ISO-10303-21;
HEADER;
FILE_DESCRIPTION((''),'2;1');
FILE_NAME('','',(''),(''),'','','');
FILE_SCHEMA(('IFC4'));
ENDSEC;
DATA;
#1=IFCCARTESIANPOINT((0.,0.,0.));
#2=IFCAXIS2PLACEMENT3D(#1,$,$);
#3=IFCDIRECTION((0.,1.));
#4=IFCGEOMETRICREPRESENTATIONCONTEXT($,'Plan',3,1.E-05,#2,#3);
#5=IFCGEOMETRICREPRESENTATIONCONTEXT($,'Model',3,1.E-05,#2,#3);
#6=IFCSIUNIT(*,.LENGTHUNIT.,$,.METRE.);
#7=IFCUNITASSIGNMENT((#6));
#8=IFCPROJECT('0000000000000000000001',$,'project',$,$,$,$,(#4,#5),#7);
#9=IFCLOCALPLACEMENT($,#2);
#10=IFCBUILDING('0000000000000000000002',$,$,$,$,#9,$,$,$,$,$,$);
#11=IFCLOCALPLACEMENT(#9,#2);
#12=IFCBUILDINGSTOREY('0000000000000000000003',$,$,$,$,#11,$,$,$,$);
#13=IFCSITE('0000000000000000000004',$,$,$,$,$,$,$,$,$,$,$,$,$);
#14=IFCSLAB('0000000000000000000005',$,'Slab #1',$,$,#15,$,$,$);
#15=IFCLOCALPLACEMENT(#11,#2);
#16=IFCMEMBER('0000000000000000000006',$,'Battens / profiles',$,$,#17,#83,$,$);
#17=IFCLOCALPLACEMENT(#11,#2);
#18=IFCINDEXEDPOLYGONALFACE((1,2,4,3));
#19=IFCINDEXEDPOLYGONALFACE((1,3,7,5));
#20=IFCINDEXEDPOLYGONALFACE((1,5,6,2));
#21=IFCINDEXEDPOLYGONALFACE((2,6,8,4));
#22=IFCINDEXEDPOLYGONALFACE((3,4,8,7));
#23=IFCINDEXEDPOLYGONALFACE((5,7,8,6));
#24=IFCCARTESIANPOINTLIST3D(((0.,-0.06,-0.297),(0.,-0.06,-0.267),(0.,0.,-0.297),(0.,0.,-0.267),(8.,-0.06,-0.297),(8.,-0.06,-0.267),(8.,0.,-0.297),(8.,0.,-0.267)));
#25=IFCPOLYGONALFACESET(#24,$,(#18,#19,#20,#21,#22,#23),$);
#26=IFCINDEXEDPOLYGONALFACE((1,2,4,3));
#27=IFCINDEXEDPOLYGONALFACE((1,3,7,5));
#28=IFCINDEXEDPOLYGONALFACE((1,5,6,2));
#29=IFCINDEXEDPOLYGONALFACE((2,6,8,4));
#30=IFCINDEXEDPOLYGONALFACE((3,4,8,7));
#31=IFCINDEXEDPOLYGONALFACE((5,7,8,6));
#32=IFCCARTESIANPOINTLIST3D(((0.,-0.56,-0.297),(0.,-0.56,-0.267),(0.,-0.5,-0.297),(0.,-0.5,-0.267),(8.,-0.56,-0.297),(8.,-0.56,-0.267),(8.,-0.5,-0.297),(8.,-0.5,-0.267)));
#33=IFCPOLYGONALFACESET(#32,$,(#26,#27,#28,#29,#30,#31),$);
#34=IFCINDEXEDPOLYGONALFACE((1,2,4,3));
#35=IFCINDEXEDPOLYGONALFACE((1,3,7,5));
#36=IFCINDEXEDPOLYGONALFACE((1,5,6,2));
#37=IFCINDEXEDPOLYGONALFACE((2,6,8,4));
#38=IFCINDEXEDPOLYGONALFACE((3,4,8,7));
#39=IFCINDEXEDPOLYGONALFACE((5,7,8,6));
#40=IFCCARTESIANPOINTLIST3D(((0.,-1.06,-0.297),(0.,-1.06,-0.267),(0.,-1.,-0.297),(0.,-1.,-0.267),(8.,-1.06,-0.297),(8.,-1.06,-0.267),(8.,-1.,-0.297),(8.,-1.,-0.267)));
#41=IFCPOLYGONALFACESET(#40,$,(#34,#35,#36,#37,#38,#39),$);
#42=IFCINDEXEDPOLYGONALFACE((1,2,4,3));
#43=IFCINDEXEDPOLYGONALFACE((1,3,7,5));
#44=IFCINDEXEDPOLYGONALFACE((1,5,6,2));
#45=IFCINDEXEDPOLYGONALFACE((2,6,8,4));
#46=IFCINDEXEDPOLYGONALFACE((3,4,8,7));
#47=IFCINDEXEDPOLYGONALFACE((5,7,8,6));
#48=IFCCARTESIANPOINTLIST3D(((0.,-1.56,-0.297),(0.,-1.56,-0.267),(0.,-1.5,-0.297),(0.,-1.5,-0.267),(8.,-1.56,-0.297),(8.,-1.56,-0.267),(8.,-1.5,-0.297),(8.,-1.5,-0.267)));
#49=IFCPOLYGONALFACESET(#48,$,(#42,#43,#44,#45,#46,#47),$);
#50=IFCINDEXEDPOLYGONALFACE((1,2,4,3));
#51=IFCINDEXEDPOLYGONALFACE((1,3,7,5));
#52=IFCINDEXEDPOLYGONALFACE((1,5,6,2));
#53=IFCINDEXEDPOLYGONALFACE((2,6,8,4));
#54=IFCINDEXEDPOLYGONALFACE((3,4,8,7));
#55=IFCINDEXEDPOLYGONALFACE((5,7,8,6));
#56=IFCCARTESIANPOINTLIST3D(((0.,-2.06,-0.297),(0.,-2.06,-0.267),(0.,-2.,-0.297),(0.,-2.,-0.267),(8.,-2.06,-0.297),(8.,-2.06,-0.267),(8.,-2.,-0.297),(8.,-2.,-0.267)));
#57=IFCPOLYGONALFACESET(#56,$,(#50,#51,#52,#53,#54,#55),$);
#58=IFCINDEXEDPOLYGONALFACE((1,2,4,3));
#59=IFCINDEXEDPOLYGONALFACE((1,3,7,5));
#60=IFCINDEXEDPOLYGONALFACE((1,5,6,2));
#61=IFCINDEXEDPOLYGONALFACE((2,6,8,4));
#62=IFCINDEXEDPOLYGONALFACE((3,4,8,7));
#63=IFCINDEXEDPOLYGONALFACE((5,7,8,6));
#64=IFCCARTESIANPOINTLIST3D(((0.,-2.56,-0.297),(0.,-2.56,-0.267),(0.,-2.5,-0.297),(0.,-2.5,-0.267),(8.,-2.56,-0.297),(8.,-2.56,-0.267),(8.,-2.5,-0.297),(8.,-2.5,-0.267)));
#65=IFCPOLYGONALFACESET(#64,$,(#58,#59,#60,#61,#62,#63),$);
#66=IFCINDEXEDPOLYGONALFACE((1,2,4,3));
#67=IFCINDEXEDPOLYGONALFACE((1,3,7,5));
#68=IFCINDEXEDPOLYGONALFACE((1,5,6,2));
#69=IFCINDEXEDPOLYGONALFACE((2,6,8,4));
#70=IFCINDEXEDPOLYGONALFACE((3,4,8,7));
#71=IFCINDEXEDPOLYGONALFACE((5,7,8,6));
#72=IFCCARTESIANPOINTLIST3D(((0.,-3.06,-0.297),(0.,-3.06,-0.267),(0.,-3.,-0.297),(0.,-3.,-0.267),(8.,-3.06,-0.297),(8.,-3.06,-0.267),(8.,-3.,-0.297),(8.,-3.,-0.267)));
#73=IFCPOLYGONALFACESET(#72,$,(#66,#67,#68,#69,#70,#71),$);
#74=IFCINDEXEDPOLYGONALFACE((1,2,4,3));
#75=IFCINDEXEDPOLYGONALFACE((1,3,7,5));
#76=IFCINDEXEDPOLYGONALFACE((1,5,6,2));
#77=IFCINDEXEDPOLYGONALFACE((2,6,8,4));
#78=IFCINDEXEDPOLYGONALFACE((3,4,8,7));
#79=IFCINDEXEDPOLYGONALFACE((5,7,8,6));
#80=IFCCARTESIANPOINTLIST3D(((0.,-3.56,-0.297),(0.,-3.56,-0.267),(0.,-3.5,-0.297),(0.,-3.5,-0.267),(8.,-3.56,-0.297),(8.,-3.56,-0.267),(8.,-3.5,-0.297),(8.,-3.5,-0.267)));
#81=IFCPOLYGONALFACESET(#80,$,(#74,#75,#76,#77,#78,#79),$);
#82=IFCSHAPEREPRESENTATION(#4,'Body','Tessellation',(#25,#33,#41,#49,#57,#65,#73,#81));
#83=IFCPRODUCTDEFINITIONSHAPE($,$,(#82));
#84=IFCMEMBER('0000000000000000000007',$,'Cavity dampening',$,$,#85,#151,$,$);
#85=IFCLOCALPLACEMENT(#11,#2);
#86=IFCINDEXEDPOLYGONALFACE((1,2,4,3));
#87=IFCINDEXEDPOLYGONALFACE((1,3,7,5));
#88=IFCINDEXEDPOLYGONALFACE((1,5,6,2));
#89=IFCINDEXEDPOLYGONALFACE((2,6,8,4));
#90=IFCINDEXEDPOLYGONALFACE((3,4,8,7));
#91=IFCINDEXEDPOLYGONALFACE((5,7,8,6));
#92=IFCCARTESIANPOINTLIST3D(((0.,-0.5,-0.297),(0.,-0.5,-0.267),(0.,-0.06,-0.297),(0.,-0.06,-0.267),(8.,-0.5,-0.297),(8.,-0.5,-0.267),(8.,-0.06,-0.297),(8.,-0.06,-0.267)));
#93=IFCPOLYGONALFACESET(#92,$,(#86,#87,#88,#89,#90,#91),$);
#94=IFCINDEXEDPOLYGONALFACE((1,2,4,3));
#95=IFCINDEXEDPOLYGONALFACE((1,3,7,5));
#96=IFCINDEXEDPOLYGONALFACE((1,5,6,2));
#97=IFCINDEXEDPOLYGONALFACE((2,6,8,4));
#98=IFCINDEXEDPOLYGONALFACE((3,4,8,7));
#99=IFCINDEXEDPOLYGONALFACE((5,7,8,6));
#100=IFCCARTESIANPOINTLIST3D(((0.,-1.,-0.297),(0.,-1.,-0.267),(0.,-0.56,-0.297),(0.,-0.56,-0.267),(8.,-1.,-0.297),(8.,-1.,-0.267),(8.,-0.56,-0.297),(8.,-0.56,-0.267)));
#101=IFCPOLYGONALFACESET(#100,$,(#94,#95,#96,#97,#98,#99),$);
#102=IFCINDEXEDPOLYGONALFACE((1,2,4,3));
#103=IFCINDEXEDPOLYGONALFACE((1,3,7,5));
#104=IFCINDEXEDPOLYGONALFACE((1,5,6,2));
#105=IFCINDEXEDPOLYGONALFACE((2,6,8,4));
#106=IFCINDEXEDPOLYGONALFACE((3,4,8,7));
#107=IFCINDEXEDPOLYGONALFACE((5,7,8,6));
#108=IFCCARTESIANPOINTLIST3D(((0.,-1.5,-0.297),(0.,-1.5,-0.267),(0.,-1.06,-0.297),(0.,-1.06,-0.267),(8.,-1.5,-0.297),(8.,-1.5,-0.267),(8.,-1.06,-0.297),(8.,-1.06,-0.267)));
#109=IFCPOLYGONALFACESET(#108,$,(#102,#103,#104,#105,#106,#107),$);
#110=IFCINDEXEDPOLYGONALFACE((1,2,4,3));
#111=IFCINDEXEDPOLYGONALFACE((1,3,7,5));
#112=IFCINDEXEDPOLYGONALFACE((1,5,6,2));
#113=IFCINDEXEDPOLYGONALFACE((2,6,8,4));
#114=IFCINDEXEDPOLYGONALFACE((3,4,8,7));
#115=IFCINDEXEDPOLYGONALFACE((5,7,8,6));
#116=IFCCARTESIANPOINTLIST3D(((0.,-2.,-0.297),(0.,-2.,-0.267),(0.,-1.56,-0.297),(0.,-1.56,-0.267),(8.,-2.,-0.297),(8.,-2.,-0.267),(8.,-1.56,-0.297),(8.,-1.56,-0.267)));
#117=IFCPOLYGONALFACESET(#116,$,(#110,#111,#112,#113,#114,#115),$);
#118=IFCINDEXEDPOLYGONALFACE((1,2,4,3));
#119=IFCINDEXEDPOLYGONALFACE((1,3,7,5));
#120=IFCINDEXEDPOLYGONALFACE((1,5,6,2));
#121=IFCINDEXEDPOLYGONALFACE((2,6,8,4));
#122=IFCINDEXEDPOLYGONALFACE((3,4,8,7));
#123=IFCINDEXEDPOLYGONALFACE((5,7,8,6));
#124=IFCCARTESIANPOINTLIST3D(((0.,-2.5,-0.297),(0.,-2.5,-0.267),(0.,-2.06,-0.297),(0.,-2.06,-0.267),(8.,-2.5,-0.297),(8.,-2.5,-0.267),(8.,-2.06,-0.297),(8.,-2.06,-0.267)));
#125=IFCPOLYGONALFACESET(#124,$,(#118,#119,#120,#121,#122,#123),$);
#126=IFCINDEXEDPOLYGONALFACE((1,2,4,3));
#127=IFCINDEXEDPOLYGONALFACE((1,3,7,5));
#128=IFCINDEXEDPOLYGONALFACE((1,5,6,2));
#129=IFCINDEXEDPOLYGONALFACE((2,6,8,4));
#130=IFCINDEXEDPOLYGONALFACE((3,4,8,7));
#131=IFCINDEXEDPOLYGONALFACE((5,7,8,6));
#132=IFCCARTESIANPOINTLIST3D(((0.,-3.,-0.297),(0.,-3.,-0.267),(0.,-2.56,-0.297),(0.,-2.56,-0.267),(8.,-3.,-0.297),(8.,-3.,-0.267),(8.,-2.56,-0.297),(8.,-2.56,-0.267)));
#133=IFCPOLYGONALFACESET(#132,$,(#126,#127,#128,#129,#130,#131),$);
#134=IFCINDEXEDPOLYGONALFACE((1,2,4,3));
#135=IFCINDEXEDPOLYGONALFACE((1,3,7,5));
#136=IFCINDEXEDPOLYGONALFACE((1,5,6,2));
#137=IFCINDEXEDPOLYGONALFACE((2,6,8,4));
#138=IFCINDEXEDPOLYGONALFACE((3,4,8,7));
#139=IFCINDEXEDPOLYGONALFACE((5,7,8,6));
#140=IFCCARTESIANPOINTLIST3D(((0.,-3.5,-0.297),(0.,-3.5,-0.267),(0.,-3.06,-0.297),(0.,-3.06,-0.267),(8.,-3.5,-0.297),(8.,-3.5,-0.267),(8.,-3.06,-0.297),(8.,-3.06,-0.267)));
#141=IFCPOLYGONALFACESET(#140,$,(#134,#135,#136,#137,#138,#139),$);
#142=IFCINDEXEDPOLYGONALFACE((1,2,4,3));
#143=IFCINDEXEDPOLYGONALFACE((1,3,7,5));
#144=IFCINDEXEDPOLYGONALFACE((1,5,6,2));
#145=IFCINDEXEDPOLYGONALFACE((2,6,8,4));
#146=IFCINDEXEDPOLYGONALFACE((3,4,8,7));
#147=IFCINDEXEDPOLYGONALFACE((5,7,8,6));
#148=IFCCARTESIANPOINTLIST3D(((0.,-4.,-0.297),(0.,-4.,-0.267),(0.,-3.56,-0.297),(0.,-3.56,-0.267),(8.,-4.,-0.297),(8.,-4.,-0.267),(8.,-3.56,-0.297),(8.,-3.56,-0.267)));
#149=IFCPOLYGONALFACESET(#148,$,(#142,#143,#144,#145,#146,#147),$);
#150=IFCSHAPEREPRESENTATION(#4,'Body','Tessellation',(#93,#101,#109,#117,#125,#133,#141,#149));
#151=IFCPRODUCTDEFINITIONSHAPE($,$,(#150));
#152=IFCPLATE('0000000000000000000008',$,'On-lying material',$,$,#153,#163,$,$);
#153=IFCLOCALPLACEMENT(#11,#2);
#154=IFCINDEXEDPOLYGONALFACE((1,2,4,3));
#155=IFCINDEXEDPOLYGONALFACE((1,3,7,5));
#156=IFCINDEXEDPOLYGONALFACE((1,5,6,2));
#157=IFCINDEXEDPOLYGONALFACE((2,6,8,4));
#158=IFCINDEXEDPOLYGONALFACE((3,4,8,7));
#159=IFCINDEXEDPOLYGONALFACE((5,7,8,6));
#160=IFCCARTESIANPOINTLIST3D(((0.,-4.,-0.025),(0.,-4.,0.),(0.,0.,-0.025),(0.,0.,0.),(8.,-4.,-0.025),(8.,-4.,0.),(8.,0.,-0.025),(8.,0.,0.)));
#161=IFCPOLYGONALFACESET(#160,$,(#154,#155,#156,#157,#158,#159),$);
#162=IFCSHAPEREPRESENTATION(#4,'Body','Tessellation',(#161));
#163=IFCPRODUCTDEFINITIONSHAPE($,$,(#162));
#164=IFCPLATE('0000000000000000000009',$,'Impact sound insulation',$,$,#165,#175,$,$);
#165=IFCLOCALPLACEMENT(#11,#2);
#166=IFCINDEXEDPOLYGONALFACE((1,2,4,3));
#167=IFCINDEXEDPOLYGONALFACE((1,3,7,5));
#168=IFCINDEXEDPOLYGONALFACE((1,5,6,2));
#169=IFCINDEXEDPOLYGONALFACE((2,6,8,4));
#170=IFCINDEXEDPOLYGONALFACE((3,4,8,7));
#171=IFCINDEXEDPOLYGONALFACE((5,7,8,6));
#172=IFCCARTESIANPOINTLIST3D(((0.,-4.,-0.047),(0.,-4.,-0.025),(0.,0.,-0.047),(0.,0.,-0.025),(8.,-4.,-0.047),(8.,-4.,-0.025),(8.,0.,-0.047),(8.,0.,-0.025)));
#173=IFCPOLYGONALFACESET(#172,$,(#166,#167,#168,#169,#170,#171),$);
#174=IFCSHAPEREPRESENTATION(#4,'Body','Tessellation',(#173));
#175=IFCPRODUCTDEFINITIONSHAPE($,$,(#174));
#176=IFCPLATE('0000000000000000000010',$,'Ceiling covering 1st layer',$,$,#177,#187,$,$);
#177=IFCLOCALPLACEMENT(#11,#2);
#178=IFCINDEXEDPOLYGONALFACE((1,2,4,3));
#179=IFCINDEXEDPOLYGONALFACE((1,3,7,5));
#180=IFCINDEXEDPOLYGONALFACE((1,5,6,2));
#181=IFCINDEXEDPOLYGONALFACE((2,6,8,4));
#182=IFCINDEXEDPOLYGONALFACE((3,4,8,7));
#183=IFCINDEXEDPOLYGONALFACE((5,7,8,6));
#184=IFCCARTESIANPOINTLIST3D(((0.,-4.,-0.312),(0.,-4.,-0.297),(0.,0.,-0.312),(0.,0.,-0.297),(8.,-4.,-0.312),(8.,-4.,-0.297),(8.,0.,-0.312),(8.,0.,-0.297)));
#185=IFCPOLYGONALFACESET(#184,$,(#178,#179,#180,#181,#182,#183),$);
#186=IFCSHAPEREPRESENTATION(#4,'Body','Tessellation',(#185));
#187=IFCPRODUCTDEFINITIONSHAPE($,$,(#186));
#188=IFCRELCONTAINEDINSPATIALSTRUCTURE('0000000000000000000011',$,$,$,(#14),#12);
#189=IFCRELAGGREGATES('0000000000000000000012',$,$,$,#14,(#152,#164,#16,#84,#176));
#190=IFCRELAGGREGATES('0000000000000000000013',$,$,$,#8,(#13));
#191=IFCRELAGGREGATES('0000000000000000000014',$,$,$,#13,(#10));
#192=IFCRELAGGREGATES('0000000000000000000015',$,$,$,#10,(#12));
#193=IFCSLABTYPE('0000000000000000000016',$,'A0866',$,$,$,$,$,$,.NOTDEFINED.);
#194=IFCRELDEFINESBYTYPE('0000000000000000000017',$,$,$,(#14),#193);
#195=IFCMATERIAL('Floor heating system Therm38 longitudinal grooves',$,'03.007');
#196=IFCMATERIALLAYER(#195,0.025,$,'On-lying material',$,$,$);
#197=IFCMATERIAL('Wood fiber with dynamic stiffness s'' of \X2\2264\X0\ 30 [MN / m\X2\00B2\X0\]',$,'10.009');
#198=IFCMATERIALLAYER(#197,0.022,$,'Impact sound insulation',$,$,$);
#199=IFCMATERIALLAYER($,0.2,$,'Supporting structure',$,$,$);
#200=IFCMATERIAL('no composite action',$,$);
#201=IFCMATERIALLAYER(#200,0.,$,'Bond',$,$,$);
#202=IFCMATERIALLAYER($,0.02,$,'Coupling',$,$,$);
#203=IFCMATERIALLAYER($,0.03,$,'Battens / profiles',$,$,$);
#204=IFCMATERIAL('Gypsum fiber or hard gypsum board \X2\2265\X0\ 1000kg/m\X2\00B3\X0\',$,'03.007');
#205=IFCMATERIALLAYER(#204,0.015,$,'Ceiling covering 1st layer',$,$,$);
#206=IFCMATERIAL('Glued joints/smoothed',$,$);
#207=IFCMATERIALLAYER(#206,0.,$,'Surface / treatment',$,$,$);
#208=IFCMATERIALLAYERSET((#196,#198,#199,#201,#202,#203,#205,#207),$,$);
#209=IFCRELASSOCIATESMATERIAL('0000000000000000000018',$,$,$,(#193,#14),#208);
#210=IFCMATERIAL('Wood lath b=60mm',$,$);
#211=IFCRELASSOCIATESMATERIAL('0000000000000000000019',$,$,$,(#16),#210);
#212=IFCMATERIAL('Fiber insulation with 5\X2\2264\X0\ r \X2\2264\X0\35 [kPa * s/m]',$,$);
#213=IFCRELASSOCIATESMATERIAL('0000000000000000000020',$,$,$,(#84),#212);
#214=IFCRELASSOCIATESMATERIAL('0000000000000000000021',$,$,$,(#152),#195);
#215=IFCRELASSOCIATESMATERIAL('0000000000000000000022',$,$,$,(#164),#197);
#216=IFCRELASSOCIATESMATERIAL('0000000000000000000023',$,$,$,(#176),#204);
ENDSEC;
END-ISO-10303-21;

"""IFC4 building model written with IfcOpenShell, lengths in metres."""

from ifc_helpers import new_model, si_unit, direction, frame, frame_2d, origin, origin_with_axes, place, context, project, spatial, rectangle, extrude, material, layer, layer_set, type_object, element, aggregate, save


model = new_model("IFC4")

# Units and contexts
plan_context = context("Plan", 3, precision=1e-05, world=origin(), true_north=direction((0.0, 1.0)))
model_context = context("Model", 3, precision=1e-05, world=origin(), true_north=direction((0.0, 1.0)))
ifc_project = project(units=[si_unit("LENGTHUNIT", "METRE")], contexts=[plan_context, model_context])

# Site, building, storey
site = spatial("IfcSite", under=ifc_project)
building_placement = place(None, origin())
building = spatial("IfcBuilding", under=site, at=building_placement)
storey_placement = place(building_placement, origin())
storey = spatial("IfcBuildingStorey", under=building, at=storey_placement)

# Slab, members, plates
ifc_material_1 = material(Name="Floor heating system Therm38 longitudinal grooves", Category="03.007")
ifc_layer_1 = layer(ifc_material_1, 0.025, Name="On-lying material")
ifc_material_2 = material(Name="Wood fiber with dynamic stiffness s' of ≤ 30 [MN / m²]", Category="10.009")
ifc_layer_2 = layer(ifc_material_2, 0.022, Name="Impact sound insulation")
ifc_layer_3 = layer(None, 0.2, Name="Supporting structure")
ifc_material_3 = material(Name="no composite action")
ifc_layer_4 = layer(ifc_material_3, 0.0, Name="Bond")
ifc_layer_5 = layer(None, 0.02, Name="Coupling")
ifc_layer_6 = layer(None, 0.03, Name="Battens / profiles")
ifc_material_4 = material(Name="Gypsum fiber or hard gypsum board ≥ 1000kg/m³", Category="03.007")
ifc_layer_7 = layer(ifc_material_4, 0.015, Name="Ceiling covering 1st layer")
ifc_material_5 = material(Name="Glued joints/smoothed")
ifc_layer_8 = layer(ifc_material_5, 0.0, Name="Surface / treatment")
ifc_layer_set = layer_set([ifc_layer_1, ifc_layer_2, ifc_layer_3, ifc_layer_4, ifc_layer_5, ifc_layer_6, ifc_layer_7, ifc_layer_8])
slab_type = type_object("IfcSlabType", Name="A0866", PredefinedType="NOTDEFINED", material=ifc_layer_set)
slab_placement = place(None, frame((0.0, 0.0, 0.0), z_axis=(0.0, 0.0, -1.0), x_axis=(1.0, 0.0, 0.0)))
slab = element("IfcSlab", 1, at=slab_placement, inside=storey, type_object=slab_type, material=ifc_layer_set, Name="Slab #1")
ifc_material_6 = material(Name="Wood lath b=60mm")
member_1_placement = place(slab_placement, origin())
member_1 = element("IfcMember", 2, at=member_1_placement, material=ifc_material_6, Name="Battens / profiles", context=plan_context, shape_type="SweptSolid", body=[
    extrude(rectangle(XDim=0.06, YDim=0.03, at=frame_2d((0.03, 0.015), x_axis=(1.0, 0.0))), frame((0.0, 0.0, 0.267), z_axis=(1.0, 0.0, 0.0), x_axis=(0.0, 1.0, 0.0)), (0.0, 0.0, 1.0), 8.0),
    extrude(rectangle(XDim=0.06, YDim=0.03, at=frame_2d((0.03, 0.015), x_axis=(1.0, 0.0))), frame((0.0, 0.5, 0.267), z_axis=(1.0, 0.0, 0.0), x_axis=(0.0, 1.0, 0.0)), (0.0, 0.0, 1.0), 8.0),
    extrude(rectangle(XDim=0.06, YDim=0.03, at=frame_2d((0.03, 0.015), x_axis=(1.0, 0.0))), frame((0.0, 1.0, 0.267), z_axis=(1.0, 0.0, 0.0), x_axis=(0.0, 1.0, 0.0)), (0.0, 0.0, 1.0), 8.0),
    extrude(rectangle(XDim=0.06, YDim=0.03, at=frame_2d((0.03, 0.015), x_axis=(1.0, 0.0))), frame((0.0, 1.5, 0.267), z_axis=(1.0, 0.0, 0.0), x_axis=(0.0, 1.0, 0.0)), (0.0, 0.0, 1.0), 8.0),
    extrude(rectangle(XDim=0.06, YDim=0.03, at=frame_2d((0.03, 0.015), x_axis=(1.0, 0.0))), frame((0.0, 2.0, 0.267), z_axis=(1.0, 0.0, 0.0), x_axis=(0.0, 1.0, 0.0)), (0.0, 0.0, 1.0), 8.0),
    extrude(rectangle(XDim=0.06, YDim=0.03, at=frame_2d((0.03, 0.015), x_axis=(1.0, 0.0))), frame((0.0, 2.5, 0.267), z_axis=(1.0, 0.0, 0.0), x_axis=(0.0, 1.0, 0.0)), (0.0, 0.0, 1.0), 8.0),
    extrude(rectangle(XDim=0.06, YDim=0.03, at=frame_2d((0.03, 0.015), x_axis=(1.0, 0.0))), frame((0.0, 3.0, 0.267), z_axis=(1.0, 0.0, 0.0), x_axis=(0.0, 1.0, 0.0)), (0.0, 0.0, 1.0), 8.0),
    extrude(rectangle(XDim=0.06, YDim=0.03, at=frame_2d((0.03, 0.015), x_axis=(1.0, 0.0))), frame((0.0, 3.5, 0.267), z_axis=(1.0, 0.0, 0.0), x_axis=(0.0, 1.0, 0.0)), (0.0, 0.0, 1.0), 8.0),
])
ifc_material_7 = material(Name="Fiber insulation with 5≤ r ≤35 [kPa * s/m]")
member_2_placement = place(slab_placement, origin())
member_2 = element("IfcMember", 3, at=member_2_placement, material=ifc_material_7, Name="Cavity dampening", context=plan_context, shape_type="SweptSolid", body=[
    extrude(rectangle(XDim=0.44, YDim=0.03, at=frame_2d((0.22, 0.015), x_axis=(1.0, 0.0))), frame((0.0, 0.06, 0.267), z_axis=(1.0, 0.0, 0.0), x_axis=(0.0, 1.0, 0.0)), (0.0, 0.0, 1.0), 8.0),
    extrude(rectangle(XDim=0.44, YDim=0.03, at=frame_2d((0.22, 0.015), x_axis=(1.0, 0.0))), frame((0.0, 0.56, 0.267), z_axis=(1.0, 0.0, 0.0), x_axis=(0.0, 1.0, 0.0)), (0.0, 0.0, 1.0), 8.0),
    extrude(rectangle(XDim=0.44, YDim=0.03, at=frame_2d((0.22, 0.015), x_axis=(1.0, 0.0))), frame((0.0, 1.06, 0.267), z_axis=(1.0, 0.0, 0.0), x_axis=(0.0, 1.0, 0.0)), (0.0, 0.0, 1.0), 8.0),
    extrude(rectangle(XDim=0.44, YDim=0.03, at=frame_2d((0.22, 0.015), x_axis=(1.0, 0.0))), frame((0.0, 1.56, 0.267), z_axis=(1.0, 0.0, 0.0), x_axis=(0.0, 1.0, 0.0)), (0.0, 0.0, 1.0), 8.0),
    extrude(rectangle(XDim=0.44, YDim=0.03, at=frame_2d((0.22, 0.015), x_axis=(1.0, 0.0))), frame((0.0, 2.06, 0.267), z_axis=(1.0, 0.0, 0.0), x_axis=(0.0, 1.0, 0.0)), (0.0, 0.0, 1.0), 8.0),
    extrude(rectangle(XDim=0.44, YDim=0.03, at=frame_2d((0.22, 0.015), x_axis=(1.0, 0.0))), frame((0.0, 2.56, 0.267), z_axis=(1.0, 0.0, 0.0), x_axis=(0.0, 1.0, 0.0)), (0.0, 0.0, 1.0), 8.0),
    extrude(rectangle(XDim=0.44, YDim=0.03, at=frame_2d((0.22, 0.015), x_axis=(1.0, 0.0))), frame((0.0, 3.06, 0.267), z_axis=(1.0, 0.0, 0.0), x_axis=(0.0, 1.0, 0.0)), (0.0, 0.0, 1.0), 8.0),
    extrude(rectangle(XDim=0.44, YDim=0.03, at=frame_2d((0.22, 0.015), x_axis=(1.0, 0.0))), frame((0.0, 3.56, 0.267), z_axis=(1.0, 0.0, 0.0), x_axis=(0.0, 1.0, 0.0)), (0.0, 0.0, 1.0), 8.0),
])
plate_1_placement = place(slab_placement, origin())
plate_1 = element("IfcPlate", 4, at=plate_1_placement, material=ifc_material_1, Name="On-lying material", context=plan_context, shape_type="SweptSolid", body=[
    extrude(rectangle(XDim=8.0, YDim=4.0, at=frame_2d((4.0, 2.0), x_axis=(1.0, 0.0))), origin_with_axes(), (0.0, 0.0, 1.0), 0.025),
])
plate_2_placement = place(slab_placement, origin())
plate_2 = element("IfcPlate", 5, at=plate_2_placement, material=ifc_material_2, Name="Impact sound insulation", context=plan_context, shape_type="SweptSolid", body=[
    extrude(rectangle(XDim=8.0, YDim=4.0, at=frame_2d((4.0, 2.0), x_axis=(1.0, 0.0))), frame((0.0, 0.0, 0.025), z_axis=(0.0, 0.0, 1.0), x_axis=(1.0, 0.0, 0.0)), (0.0, 0.0, 1.0), 0.022),
])
plate_3_placement = place(slab_placement, origin())
plate_3 = element("IfcPlate", 6, at=plate_3_placement, material=ifc_material_4, Name="Ceiling covering 1st layer", context=plan_context, shape_type="SweptSolid", body=[
    extrude(rectangle(XDim=8.0, YDim=4.0, at=frame_2d((4.0, 2.0), x_axis=(1.0, 0.0))), frame((0.0, 0.0, 0.297), z_axis=(0.0, 0.0, 1.0), x_axis=(1.0, 0.0, 0.0)), (0.0, 0.0, 1.0), 0.015),
])
aggregate(slab, [plate_1, plate_2, member_1, member_2, plate_3])

save(model, "model.ifc")
